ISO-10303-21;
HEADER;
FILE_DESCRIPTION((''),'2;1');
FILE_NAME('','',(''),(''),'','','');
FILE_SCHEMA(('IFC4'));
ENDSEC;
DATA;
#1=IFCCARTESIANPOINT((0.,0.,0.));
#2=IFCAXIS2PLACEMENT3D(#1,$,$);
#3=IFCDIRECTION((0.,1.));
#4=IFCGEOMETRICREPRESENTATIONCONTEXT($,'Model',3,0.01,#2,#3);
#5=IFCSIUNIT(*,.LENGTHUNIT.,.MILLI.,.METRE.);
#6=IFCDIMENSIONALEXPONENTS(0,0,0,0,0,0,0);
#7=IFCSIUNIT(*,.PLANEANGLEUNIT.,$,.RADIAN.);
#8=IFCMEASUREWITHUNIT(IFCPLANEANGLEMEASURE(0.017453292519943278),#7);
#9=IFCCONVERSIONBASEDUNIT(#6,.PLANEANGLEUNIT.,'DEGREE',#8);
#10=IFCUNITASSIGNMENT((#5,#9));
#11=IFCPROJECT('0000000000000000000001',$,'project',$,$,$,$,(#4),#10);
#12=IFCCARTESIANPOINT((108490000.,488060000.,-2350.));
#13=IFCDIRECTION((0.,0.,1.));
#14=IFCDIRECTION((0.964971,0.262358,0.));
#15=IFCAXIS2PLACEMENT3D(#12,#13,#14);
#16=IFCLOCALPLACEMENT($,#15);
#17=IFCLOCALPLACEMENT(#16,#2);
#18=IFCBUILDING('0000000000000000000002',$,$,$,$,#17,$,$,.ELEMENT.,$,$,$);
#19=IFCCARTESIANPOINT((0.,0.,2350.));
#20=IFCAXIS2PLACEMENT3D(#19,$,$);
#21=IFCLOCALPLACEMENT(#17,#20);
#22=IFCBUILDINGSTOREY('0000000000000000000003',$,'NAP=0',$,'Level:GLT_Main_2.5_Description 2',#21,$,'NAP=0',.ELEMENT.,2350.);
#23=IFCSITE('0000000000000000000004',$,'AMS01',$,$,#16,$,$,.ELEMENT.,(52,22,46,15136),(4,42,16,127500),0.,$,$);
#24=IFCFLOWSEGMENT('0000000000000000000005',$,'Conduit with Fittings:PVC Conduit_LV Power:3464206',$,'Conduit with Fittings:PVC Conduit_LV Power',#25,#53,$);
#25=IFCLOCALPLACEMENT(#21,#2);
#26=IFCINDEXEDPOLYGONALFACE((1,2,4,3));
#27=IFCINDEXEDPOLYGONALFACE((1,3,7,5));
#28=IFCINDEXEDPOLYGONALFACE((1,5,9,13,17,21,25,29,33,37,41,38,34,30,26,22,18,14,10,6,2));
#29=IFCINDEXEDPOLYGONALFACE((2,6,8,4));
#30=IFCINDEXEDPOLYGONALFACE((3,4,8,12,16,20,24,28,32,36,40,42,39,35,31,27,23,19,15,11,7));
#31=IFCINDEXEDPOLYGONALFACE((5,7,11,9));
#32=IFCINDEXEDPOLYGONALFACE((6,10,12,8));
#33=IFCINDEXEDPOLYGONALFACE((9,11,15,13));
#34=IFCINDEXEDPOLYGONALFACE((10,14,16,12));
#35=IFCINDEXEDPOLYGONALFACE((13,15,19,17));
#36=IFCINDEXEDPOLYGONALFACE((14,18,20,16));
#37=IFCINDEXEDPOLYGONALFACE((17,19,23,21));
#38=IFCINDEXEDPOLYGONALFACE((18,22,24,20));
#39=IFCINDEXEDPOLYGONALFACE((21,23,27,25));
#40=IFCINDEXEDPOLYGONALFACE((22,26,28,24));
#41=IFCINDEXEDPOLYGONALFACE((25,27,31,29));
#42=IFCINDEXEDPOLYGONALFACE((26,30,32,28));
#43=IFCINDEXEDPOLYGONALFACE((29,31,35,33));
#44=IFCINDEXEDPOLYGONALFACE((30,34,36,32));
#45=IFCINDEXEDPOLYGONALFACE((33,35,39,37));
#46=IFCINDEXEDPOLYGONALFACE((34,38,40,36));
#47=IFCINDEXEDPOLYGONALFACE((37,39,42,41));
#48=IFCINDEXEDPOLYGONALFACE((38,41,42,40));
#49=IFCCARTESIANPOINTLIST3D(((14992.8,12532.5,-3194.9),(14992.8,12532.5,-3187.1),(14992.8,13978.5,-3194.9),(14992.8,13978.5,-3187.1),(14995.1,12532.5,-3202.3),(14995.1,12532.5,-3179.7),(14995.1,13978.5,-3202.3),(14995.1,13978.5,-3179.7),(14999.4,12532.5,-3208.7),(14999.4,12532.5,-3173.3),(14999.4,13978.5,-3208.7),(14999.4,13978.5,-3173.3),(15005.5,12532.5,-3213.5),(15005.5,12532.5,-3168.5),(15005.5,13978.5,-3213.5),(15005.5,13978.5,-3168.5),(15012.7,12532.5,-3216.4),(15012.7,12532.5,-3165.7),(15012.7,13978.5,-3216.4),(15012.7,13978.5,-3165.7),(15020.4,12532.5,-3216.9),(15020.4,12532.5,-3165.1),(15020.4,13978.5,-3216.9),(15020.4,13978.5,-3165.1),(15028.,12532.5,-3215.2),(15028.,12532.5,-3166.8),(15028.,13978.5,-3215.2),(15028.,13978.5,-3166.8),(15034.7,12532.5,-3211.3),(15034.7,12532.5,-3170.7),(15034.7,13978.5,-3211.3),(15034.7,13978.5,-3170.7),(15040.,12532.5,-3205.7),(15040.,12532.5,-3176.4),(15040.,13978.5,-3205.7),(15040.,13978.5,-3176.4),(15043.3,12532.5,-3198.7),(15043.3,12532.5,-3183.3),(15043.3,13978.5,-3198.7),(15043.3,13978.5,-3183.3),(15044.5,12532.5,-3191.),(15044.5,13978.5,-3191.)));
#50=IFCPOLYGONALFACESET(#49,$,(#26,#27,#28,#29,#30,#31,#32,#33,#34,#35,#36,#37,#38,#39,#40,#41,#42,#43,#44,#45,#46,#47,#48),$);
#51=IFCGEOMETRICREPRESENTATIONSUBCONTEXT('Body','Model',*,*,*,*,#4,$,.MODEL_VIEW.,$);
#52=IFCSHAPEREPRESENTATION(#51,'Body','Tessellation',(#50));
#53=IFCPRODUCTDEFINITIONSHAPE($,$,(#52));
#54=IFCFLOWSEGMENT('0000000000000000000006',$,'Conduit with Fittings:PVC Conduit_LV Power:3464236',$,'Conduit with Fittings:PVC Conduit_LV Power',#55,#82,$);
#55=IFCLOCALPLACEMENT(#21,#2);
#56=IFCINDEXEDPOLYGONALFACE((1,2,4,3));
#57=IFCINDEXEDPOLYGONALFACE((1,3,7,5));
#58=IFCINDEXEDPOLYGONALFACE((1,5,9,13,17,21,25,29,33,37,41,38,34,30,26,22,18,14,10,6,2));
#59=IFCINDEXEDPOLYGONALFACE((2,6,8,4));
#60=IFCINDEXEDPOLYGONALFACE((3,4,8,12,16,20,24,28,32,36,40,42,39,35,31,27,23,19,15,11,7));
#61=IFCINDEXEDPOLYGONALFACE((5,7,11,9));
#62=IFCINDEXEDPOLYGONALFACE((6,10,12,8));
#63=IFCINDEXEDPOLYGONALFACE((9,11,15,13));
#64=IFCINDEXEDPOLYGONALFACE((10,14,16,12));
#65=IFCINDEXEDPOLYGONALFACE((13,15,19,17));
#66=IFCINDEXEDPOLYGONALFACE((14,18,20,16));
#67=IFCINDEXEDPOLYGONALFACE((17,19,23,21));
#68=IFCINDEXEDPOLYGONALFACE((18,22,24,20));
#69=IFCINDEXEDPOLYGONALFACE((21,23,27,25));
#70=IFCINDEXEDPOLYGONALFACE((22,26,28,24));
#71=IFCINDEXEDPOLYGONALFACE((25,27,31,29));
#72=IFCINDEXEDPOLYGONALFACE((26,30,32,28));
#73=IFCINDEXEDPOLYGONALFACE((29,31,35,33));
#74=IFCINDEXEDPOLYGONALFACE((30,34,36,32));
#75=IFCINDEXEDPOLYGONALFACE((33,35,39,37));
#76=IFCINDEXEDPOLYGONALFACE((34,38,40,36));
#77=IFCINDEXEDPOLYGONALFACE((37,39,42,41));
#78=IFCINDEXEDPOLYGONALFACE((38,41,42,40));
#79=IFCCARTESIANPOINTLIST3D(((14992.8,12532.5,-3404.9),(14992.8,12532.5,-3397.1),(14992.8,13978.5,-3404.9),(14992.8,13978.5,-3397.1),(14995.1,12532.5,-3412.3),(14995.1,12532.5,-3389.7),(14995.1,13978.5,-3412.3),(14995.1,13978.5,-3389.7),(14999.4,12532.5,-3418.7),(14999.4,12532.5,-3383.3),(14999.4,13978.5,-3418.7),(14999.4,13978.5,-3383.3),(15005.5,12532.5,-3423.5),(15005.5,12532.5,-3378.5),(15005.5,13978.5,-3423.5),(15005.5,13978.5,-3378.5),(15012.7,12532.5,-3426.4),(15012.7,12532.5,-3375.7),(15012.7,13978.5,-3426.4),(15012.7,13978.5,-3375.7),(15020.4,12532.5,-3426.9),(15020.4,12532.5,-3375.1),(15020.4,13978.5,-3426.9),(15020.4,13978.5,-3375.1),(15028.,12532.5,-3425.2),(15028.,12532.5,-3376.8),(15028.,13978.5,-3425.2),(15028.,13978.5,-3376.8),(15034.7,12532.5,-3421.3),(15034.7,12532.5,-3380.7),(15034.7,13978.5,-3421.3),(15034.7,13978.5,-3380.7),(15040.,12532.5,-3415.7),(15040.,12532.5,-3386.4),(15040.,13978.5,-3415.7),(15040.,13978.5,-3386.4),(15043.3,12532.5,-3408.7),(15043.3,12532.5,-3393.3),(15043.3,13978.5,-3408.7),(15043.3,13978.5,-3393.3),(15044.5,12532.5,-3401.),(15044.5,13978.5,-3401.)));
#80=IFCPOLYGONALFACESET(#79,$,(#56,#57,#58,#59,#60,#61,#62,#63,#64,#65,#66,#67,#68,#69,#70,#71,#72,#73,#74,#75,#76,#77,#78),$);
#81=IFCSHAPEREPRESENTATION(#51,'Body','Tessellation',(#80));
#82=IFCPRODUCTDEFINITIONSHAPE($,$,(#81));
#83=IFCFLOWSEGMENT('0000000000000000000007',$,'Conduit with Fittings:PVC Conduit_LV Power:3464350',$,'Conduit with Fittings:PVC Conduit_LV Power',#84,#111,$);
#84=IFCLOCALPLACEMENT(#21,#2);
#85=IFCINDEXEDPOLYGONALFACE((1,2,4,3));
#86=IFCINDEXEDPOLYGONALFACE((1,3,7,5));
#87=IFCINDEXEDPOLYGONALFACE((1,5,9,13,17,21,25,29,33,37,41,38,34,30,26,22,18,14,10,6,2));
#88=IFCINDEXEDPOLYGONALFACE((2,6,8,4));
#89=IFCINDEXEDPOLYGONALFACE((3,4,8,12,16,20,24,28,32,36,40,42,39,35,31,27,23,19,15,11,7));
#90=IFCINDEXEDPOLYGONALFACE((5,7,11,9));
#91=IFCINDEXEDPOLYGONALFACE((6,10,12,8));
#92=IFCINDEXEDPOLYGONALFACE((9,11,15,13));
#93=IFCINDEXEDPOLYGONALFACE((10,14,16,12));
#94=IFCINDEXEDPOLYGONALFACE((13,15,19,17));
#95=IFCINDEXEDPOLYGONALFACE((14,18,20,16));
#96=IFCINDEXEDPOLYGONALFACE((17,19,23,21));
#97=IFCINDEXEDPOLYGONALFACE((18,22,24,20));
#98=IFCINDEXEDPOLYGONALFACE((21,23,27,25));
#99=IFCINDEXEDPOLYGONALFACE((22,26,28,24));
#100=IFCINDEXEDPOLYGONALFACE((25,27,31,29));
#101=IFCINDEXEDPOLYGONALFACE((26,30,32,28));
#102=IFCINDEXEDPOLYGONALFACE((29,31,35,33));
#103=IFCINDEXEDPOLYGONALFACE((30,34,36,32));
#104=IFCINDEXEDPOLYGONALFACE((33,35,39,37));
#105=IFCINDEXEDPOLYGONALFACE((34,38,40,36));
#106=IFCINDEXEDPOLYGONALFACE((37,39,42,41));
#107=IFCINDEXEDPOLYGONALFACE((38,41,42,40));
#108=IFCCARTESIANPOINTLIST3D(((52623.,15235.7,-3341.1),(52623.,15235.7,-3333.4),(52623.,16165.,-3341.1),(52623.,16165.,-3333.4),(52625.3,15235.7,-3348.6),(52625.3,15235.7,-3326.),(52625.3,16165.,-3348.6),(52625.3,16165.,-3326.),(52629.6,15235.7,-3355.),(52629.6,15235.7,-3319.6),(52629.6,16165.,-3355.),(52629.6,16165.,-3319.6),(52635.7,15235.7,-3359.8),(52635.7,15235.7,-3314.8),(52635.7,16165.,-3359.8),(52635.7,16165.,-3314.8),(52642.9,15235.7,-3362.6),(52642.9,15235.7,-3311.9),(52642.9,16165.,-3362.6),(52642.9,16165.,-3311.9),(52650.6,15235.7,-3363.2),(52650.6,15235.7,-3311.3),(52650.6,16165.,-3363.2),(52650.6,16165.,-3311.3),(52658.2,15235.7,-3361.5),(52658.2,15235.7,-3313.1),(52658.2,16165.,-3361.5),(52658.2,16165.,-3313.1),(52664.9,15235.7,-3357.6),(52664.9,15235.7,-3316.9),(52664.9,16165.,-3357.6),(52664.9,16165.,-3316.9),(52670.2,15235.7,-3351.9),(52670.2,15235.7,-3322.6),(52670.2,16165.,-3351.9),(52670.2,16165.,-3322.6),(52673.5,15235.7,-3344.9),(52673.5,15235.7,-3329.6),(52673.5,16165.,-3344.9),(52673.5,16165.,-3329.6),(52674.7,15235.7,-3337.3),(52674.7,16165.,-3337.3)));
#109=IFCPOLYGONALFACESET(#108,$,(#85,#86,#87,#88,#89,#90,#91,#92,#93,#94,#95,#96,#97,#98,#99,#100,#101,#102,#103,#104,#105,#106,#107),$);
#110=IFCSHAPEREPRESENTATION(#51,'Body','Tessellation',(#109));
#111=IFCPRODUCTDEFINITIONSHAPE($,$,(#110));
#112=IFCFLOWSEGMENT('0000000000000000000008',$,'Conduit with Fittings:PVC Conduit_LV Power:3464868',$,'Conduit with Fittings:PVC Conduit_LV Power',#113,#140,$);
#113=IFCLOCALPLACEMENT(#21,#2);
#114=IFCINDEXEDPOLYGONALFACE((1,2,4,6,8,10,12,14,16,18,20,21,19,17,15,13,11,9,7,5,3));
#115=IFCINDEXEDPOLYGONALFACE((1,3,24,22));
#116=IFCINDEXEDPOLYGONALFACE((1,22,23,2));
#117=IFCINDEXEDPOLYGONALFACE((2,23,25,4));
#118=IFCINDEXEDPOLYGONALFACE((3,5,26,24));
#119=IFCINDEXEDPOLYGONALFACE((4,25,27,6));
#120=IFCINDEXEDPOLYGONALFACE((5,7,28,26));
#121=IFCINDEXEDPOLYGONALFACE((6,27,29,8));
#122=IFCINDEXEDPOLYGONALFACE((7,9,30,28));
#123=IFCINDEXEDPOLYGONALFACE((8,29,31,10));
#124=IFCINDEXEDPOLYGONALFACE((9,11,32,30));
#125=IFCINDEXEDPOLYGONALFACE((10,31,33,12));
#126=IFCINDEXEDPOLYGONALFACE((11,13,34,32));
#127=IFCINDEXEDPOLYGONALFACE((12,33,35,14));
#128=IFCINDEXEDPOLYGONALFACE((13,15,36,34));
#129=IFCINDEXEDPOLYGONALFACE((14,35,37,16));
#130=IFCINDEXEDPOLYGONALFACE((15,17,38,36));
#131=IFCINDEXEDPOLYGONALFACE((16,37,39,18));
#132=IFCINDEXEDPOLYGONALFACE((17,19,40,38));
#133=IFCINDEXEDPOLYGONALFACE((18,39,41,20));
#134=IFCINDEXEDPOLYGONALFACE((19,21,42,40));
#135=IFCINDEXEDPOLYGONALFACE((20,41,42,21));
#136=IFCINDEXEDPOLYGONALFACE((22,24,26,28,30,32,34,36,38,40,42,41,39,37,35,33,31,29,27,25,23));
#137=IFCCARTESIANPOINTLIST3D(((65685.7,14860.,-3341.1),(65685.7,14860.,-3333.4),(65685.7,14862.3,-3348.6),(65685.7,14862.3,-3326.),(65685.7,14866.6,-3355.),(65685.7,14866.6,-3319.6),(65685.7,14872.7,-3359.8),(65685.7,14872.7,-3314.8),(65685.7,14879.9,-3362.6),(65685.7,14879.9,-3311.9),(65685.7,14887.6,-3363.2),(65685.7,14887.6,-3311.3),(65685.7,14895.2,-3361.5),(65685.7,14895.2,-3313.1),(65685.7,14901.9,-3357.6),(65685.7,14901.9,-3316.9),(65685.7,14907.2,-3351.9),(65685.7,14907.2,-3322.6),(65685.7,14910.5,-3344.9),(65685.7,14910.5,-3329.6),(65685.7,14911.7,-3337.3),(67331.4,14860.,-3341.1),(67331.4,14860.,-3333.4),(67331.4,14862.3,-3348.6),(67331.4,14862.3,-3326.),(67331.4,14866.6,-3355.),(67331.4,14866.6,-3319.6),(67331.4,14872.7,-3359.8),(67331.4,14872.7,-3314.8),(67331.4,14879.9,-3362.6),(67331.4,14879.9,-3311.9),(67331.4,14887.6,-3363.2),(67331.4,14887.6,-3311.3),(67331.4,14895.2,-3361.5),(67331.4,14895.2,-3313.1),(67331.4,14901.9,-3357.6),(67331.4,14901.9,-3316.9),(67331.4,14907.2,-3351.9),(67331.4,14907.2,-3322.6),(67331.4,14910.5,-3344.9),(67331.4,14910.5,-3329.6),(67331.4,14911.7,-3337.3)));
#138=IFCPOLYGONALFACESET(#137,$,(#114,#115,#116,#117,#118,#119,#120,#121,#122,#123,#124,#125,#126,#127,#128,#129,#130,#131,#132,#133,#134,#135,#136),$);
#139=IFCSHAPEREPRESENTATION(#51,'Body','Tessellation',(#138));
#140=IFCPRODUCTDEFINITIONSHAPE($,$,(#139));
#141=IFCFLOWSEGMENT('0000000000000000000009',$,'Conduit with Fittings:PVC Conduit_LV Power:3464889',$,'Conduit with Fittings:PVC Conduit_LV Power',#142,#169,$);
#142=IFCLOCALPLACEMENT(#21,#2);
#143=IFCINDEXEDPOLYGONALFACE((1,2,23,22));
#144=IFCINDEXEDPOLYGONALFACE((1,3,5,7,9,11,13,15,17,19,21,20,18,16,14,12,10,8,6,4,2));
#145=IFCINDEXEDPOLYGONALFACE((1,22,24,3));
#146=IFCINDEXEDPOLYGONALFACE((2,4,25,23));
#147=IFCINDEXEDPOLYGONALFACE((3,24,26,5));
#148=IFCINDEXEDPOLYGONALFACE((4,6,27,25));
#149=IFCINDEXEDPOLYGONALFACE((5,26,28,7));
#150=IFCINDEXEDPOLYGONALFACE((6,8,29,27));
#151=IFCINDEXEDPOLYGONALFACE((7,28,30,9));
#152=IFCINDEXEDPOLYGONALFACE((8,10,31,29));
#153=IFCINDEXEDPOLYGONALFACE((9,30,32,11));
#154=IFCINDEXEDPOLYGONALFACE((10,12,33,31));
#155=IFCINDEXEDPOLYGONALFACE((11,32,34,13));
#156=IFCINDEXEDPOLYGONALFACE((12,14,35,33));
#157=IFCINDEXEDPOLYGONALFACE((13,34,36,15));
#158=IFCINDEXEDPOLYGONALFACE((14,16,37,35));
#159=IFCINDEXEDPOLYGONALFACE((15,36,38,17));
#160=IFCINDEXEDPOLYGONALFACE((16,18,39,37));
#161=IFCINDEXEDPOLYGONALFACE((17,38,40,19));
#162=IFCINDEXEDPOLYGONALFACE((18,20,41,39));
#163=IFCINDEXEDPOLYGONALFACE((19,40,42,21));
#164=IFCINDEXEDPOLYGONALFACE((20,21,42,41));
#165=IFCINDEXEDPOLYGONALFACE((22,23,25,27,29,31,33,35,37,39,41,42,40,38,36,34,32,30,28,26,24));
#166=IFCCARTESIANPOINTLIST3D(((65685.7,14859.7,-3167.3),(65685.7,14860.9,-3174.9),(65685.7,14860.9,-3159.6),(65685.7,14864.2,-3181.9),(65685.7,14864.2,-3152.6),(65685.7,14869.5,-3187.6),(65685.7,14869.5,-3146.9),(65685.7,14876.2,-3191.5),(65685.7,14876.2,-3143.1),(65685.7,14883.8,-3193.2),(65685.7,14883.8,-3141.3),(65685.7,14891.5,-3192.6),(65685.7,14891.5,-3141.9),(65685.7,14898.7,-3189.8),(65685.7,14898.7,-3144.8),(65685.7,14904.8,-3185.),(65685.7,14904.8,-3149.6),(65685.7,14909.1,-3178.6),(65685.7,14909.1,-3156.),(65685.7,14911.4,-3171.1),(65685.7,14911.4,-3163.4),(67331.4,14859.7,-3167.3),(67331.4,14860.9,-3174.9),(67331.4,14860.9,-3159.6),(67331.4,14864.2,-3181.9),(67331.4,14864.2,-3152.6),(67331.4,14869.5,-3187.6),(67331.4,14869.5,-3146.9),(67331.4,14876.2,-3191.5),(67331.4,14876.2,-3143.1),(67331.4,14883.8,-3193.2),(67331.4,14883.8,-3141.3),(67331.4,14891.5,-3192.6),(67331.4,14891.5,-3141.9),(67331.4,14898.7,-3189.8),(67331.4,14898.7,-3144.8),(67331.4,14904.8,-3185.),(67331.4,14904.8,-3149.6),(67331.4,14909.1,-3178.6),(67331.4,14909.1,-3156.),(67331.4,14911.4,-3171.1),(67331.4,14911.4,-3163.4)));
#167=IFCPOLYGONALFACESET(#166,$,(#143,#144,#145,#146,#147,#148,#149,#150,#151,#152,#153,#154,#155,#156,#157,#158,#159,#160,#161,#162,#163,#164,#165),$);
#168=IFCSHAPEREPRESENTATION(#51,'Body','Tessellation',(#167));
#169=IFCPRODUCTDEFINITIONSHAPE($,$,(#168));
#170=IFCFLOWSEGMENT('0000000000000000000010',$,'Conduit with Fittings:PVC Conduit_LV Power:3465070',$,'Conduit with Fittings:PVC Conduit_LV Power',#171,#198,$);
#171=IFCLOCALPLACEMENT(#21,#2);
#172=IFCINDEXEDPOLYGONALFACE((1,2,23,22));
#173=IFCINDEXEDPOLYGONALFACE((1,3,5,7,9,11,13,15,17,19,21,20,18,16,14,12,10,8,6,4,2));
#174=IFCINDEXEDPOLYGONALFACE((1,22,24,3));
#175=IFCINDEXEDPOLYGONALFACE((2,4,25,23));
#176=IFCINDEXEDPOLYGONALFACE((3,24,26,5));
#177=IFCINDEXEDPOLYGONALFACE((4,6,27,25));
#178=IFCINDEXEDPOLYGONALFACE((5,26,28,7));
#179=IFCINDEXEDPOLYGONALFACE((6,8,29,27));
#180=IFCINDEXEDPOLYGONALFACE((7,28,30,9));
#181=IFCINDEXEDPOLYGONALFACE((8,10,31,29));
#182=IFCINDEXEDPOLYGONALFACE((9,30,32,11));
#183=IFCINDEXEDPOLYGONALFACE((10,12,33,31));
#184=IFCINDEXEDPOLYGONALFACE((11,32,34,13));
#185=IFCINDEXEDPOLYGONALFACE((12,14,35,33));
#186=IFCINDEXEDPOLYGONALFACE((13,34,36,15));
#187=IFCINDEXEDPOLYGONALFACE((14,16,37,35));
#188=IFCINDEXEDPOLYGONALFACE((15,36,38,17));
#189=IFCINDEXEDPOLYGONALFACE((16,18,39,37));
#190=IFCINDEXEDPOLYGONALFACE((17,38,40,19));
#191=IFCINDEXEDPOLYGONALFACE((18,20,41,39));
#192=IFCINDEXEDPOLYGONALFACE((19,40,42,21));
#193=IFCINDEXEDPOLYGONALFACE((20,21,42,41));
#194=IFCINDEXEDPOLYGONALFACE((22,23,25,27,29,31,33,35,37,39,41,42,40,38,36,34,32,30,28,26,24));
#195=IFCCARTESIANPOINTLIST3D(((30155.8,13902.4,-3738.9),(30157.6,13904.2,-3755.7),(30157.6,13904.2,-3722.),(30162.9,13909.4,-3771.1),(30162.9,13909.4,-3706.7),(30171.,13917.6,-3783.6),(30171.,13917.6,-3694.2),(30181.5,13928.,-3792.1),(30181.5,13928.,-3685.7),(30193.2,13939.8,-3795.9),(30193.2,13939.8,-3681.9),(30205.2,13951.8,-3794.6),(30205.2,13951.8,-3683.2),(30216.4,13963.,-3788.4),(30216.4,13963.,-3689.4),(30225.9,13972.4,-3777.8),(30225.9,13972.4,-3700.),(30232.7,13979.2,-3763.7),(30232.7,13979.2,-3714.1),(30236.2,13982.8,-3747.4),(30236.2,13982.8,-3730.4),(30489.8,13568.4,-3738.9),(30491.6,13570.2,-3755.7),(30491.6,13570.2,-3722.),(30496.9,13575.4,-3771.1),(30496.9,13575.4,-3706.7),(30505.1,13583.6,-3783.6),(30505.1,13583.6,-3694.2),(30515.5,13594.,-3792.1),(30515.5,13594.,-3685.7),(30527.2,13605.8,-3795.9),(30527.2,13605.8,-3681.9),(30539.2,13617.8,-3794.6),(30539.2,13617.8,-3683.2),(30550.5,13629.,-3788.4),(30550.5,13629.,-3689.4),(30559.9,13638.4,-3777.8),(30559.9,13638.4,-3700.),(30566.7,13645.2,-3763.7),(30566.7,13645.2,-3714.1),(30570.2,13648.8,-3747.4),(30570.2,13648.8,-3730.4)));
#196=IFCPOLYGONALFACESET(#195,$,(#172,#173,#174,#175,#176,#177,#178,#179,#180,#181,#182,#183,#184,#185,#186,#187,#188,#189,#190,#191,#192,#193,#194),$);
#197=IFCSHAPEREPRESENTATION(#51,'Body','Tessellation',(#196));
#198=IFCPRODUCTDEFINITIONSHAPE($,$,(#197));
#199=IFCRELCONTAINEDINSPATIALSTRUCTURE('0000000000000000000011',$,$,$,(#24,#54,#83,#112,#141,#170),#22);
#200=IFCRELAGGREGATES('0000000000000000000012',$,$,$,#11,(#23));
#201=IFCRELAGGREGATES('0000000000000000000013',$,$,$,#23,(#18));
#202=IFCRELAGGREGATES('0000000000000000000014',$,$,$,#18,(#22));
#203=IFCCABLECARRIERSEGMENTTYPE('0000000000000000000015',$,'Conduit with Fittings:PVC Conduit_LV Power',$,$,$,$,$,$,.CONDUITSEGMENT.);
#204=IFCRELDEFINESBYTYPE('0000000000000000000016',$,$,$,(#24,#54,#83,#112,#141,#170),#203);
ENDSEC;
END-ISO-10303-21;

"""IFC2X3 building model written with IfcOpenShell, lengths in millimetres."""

from ifc_helpers import new_model, entity, si_unit, converted_unit, direction, frame, origin, origin_2d_with_axis, place, context, subcontext, project, spatial, circle, extrude, type_object, element, save


model = new_model("IFC2X3")

# Units and contexts
model_context = context("Model", 3, precision=0.01, world=origin(), true_north=direction((0.0, 1.0)))
body_context = subcontext(model_context, "Body", "Model", "MODEL_VIEW")
ifc_project = project(units=[si_unit("LENGTHUNIT", "METRE", prefix="MILLI"), converted_unit("PLANEANGLEUNIT", "DEGREE", entity("IfcPlaneAngleMeasure", 0.017453292519943278), si_unit("PLANEANGLEUNIT", "RADIAN"), dimensions=[0, 0, 0, 0, 0, 0, 0])], contexts=[model_context])

# Site, building, storey
site_placement = place(None, frame((108490000.0, 488060000.0, -2350.0), z_axis=(0.0, 0.0, 1.0), x_axis=(0.964971, 0.262358, 0.0)))
site = spatial("IfcSite", under=ifc_project, at=site_placement, Name="AMS01", CompositionType="ELEMENT", RefLatitude=(52, 22, 46, 15136), RefLongitude=(4, 42, 16, 127500), RefElevation=0.0)
building_placement = place(site_placement, origin())
building = spatial("IfcBuilding", under=site, at=building_placement, CompositionType="ELEMENT")
storey_placement = place(building_placement, frame((0.0, 0.0, 2350.0)))
storey = spatial("IfcBuildingStorey", under=building, at=storey_placement, Name="NAP=0", ObjectType="Level:GLT_Main_2.5_Description 2", LongName="NAP=0", CompositionType="ELEMENT", Elevation=2350.0)

# Flow segments
cable_carrier_segment_type = type_object("IfcCableCarrierSegmentType", Name="Conduit with Fittings:PVC Conduit_LV Power", PredefinedType="CONDUITSEGMENT")
flow_segment_1_placement = place(storey_placement, origin())
element("IfcFlowSegment", 1, at=flow_segment_1_placement, inside=storey, type_object=cable_carrier_segment_type, Name="Conduit with Fittings:PVC Conduit_LV Power:3464206", ObjectType="Conduit with Fittings:PVC Conduit_LV Power", context=body_context, shape_type="SweptSolid", body=[
    extrude(circle(Radius=26.0, at=origin_2d_with_axis()), frame((15018.5, 12532.5, -3191.0), z_axis=(0.0, 1.0, 0.0), x_axis=(1.0, 0.0, 0.0)), (0.0, 0.0, 1.0), 1446.1),
])
flow_segment_2_placement = place(storey_placement, origin())
element("IfcFlowSegment", 2, at=flow_segment_2_placement, inside=storey, type_object=cable_carrier_segment_type, Name="Conduit with Fittings:PVC Conduit_LV Power:3464236", ObjectType="Conduit with Fittings:PVC Conduit_LV Power", context=body_context, shape_type="SweptSolid", body=[
    extrude(circle(Radius=26.0, at=origin_2d_with_axis()), frame((15018.5, 12532.5, -3401.0), z_axis=(0.0, 1.0, 0.0), x_axis=(1.0, 0.0, 0.0)), (0.0, 0.0, 1.0), 1446.1),
])
flow_segment_3_placement = place(storey_placement, origin())
element("IfcFlowSegment", 3, at=flow_segment_3_placement, inside=storey, type_object=cable_carrier_segment_type, Name="Conduit with Fittings:PVC Conduit_LV Power:3464350", ObjectType="Conduit with Fittings:PVC Conduit_LV Power", context=body_context, shape_type="SweptSolid", body=[
    extrude(circle(Radius=26.0, at=origin_2d_with_axis()), frame((52648.7, 15235.7, -3337.3), z_axis=(0.0, 1.0, 0.0), x_axis=(1.0, 0.0, 0.0)), (0.0, 0.0, 1.0), 929.3),
])
flow_segment_4_placement = place(storey_placement, origin())
element("IfcFlowSegment", 4, at=flow_segment_4_placement, inside=storey, type_object=cable_carrier_segment_type, Name="Conduit with Fittings:PVC Conduit_LV Power:3464868", ObjectType="Conduit with Fittings:PVC Conduit_LV Power", context=body_context, shape_type="SweptSolid", body=[
    extrude(circle(Radius=26.0, at=origin_2d_with_axis()), frame((65685.7, 14885.7, -3337.3), z_axis=(1.0, 0.0, 0.0), x_axis=(0.0, 1.0, 0.0)), (0.0, 0.0, 1.0), 1645.7),
])
flow_segment_5_placement = place(storey_placement, origin())
element("IfcFlowSegment", 5, at=flow_segment_5_placement, inside=storey, type_object=cable_carrier_segment_type, Name="Conduit with Fittings:PVC Conduit_LV Power:3464889", ObjectType="Conduit with Fittings:PVC Conduit_LV Power", context=body_context, shape_type="SweptSolid", body=[
    extrude(circle(Radius=26.0, at=origin_2d_with_axis()), frame((65685.7, 14885.7, -3167.3), z_axis=(1.0, 0.0, 0.0), x_axis=(0.0, -1.0, 0.0)), (0.0, 0.0, 1.0), 1645.7),
])
flow_segment_6_placement = place(storey_placement, origin())
element("IfcFlowSegment", 6, at=flow_segment_6_placement, inside=storey, type_object=cable_carrier_segment_type, Name="Conduit with Fittings:PVC Conduit_LV Power:3465070", ObjectType="Conduit with Fittings:PVC Conduit_LV Power", context=body_context, shape_type="SweptSolid", body=[
    extrude(circle(Radius=57.2, at=origin_2d_with_axis()), frame((30196.2, 13942.8, -3738.9), z_axis=(0.707107, -0.707107, 0.0), x_axis=(-0.707107, -0.707107, 0.0)), (0.0, 0.0, 1.0), 472.4),
])

save(model, "model.ifc")
